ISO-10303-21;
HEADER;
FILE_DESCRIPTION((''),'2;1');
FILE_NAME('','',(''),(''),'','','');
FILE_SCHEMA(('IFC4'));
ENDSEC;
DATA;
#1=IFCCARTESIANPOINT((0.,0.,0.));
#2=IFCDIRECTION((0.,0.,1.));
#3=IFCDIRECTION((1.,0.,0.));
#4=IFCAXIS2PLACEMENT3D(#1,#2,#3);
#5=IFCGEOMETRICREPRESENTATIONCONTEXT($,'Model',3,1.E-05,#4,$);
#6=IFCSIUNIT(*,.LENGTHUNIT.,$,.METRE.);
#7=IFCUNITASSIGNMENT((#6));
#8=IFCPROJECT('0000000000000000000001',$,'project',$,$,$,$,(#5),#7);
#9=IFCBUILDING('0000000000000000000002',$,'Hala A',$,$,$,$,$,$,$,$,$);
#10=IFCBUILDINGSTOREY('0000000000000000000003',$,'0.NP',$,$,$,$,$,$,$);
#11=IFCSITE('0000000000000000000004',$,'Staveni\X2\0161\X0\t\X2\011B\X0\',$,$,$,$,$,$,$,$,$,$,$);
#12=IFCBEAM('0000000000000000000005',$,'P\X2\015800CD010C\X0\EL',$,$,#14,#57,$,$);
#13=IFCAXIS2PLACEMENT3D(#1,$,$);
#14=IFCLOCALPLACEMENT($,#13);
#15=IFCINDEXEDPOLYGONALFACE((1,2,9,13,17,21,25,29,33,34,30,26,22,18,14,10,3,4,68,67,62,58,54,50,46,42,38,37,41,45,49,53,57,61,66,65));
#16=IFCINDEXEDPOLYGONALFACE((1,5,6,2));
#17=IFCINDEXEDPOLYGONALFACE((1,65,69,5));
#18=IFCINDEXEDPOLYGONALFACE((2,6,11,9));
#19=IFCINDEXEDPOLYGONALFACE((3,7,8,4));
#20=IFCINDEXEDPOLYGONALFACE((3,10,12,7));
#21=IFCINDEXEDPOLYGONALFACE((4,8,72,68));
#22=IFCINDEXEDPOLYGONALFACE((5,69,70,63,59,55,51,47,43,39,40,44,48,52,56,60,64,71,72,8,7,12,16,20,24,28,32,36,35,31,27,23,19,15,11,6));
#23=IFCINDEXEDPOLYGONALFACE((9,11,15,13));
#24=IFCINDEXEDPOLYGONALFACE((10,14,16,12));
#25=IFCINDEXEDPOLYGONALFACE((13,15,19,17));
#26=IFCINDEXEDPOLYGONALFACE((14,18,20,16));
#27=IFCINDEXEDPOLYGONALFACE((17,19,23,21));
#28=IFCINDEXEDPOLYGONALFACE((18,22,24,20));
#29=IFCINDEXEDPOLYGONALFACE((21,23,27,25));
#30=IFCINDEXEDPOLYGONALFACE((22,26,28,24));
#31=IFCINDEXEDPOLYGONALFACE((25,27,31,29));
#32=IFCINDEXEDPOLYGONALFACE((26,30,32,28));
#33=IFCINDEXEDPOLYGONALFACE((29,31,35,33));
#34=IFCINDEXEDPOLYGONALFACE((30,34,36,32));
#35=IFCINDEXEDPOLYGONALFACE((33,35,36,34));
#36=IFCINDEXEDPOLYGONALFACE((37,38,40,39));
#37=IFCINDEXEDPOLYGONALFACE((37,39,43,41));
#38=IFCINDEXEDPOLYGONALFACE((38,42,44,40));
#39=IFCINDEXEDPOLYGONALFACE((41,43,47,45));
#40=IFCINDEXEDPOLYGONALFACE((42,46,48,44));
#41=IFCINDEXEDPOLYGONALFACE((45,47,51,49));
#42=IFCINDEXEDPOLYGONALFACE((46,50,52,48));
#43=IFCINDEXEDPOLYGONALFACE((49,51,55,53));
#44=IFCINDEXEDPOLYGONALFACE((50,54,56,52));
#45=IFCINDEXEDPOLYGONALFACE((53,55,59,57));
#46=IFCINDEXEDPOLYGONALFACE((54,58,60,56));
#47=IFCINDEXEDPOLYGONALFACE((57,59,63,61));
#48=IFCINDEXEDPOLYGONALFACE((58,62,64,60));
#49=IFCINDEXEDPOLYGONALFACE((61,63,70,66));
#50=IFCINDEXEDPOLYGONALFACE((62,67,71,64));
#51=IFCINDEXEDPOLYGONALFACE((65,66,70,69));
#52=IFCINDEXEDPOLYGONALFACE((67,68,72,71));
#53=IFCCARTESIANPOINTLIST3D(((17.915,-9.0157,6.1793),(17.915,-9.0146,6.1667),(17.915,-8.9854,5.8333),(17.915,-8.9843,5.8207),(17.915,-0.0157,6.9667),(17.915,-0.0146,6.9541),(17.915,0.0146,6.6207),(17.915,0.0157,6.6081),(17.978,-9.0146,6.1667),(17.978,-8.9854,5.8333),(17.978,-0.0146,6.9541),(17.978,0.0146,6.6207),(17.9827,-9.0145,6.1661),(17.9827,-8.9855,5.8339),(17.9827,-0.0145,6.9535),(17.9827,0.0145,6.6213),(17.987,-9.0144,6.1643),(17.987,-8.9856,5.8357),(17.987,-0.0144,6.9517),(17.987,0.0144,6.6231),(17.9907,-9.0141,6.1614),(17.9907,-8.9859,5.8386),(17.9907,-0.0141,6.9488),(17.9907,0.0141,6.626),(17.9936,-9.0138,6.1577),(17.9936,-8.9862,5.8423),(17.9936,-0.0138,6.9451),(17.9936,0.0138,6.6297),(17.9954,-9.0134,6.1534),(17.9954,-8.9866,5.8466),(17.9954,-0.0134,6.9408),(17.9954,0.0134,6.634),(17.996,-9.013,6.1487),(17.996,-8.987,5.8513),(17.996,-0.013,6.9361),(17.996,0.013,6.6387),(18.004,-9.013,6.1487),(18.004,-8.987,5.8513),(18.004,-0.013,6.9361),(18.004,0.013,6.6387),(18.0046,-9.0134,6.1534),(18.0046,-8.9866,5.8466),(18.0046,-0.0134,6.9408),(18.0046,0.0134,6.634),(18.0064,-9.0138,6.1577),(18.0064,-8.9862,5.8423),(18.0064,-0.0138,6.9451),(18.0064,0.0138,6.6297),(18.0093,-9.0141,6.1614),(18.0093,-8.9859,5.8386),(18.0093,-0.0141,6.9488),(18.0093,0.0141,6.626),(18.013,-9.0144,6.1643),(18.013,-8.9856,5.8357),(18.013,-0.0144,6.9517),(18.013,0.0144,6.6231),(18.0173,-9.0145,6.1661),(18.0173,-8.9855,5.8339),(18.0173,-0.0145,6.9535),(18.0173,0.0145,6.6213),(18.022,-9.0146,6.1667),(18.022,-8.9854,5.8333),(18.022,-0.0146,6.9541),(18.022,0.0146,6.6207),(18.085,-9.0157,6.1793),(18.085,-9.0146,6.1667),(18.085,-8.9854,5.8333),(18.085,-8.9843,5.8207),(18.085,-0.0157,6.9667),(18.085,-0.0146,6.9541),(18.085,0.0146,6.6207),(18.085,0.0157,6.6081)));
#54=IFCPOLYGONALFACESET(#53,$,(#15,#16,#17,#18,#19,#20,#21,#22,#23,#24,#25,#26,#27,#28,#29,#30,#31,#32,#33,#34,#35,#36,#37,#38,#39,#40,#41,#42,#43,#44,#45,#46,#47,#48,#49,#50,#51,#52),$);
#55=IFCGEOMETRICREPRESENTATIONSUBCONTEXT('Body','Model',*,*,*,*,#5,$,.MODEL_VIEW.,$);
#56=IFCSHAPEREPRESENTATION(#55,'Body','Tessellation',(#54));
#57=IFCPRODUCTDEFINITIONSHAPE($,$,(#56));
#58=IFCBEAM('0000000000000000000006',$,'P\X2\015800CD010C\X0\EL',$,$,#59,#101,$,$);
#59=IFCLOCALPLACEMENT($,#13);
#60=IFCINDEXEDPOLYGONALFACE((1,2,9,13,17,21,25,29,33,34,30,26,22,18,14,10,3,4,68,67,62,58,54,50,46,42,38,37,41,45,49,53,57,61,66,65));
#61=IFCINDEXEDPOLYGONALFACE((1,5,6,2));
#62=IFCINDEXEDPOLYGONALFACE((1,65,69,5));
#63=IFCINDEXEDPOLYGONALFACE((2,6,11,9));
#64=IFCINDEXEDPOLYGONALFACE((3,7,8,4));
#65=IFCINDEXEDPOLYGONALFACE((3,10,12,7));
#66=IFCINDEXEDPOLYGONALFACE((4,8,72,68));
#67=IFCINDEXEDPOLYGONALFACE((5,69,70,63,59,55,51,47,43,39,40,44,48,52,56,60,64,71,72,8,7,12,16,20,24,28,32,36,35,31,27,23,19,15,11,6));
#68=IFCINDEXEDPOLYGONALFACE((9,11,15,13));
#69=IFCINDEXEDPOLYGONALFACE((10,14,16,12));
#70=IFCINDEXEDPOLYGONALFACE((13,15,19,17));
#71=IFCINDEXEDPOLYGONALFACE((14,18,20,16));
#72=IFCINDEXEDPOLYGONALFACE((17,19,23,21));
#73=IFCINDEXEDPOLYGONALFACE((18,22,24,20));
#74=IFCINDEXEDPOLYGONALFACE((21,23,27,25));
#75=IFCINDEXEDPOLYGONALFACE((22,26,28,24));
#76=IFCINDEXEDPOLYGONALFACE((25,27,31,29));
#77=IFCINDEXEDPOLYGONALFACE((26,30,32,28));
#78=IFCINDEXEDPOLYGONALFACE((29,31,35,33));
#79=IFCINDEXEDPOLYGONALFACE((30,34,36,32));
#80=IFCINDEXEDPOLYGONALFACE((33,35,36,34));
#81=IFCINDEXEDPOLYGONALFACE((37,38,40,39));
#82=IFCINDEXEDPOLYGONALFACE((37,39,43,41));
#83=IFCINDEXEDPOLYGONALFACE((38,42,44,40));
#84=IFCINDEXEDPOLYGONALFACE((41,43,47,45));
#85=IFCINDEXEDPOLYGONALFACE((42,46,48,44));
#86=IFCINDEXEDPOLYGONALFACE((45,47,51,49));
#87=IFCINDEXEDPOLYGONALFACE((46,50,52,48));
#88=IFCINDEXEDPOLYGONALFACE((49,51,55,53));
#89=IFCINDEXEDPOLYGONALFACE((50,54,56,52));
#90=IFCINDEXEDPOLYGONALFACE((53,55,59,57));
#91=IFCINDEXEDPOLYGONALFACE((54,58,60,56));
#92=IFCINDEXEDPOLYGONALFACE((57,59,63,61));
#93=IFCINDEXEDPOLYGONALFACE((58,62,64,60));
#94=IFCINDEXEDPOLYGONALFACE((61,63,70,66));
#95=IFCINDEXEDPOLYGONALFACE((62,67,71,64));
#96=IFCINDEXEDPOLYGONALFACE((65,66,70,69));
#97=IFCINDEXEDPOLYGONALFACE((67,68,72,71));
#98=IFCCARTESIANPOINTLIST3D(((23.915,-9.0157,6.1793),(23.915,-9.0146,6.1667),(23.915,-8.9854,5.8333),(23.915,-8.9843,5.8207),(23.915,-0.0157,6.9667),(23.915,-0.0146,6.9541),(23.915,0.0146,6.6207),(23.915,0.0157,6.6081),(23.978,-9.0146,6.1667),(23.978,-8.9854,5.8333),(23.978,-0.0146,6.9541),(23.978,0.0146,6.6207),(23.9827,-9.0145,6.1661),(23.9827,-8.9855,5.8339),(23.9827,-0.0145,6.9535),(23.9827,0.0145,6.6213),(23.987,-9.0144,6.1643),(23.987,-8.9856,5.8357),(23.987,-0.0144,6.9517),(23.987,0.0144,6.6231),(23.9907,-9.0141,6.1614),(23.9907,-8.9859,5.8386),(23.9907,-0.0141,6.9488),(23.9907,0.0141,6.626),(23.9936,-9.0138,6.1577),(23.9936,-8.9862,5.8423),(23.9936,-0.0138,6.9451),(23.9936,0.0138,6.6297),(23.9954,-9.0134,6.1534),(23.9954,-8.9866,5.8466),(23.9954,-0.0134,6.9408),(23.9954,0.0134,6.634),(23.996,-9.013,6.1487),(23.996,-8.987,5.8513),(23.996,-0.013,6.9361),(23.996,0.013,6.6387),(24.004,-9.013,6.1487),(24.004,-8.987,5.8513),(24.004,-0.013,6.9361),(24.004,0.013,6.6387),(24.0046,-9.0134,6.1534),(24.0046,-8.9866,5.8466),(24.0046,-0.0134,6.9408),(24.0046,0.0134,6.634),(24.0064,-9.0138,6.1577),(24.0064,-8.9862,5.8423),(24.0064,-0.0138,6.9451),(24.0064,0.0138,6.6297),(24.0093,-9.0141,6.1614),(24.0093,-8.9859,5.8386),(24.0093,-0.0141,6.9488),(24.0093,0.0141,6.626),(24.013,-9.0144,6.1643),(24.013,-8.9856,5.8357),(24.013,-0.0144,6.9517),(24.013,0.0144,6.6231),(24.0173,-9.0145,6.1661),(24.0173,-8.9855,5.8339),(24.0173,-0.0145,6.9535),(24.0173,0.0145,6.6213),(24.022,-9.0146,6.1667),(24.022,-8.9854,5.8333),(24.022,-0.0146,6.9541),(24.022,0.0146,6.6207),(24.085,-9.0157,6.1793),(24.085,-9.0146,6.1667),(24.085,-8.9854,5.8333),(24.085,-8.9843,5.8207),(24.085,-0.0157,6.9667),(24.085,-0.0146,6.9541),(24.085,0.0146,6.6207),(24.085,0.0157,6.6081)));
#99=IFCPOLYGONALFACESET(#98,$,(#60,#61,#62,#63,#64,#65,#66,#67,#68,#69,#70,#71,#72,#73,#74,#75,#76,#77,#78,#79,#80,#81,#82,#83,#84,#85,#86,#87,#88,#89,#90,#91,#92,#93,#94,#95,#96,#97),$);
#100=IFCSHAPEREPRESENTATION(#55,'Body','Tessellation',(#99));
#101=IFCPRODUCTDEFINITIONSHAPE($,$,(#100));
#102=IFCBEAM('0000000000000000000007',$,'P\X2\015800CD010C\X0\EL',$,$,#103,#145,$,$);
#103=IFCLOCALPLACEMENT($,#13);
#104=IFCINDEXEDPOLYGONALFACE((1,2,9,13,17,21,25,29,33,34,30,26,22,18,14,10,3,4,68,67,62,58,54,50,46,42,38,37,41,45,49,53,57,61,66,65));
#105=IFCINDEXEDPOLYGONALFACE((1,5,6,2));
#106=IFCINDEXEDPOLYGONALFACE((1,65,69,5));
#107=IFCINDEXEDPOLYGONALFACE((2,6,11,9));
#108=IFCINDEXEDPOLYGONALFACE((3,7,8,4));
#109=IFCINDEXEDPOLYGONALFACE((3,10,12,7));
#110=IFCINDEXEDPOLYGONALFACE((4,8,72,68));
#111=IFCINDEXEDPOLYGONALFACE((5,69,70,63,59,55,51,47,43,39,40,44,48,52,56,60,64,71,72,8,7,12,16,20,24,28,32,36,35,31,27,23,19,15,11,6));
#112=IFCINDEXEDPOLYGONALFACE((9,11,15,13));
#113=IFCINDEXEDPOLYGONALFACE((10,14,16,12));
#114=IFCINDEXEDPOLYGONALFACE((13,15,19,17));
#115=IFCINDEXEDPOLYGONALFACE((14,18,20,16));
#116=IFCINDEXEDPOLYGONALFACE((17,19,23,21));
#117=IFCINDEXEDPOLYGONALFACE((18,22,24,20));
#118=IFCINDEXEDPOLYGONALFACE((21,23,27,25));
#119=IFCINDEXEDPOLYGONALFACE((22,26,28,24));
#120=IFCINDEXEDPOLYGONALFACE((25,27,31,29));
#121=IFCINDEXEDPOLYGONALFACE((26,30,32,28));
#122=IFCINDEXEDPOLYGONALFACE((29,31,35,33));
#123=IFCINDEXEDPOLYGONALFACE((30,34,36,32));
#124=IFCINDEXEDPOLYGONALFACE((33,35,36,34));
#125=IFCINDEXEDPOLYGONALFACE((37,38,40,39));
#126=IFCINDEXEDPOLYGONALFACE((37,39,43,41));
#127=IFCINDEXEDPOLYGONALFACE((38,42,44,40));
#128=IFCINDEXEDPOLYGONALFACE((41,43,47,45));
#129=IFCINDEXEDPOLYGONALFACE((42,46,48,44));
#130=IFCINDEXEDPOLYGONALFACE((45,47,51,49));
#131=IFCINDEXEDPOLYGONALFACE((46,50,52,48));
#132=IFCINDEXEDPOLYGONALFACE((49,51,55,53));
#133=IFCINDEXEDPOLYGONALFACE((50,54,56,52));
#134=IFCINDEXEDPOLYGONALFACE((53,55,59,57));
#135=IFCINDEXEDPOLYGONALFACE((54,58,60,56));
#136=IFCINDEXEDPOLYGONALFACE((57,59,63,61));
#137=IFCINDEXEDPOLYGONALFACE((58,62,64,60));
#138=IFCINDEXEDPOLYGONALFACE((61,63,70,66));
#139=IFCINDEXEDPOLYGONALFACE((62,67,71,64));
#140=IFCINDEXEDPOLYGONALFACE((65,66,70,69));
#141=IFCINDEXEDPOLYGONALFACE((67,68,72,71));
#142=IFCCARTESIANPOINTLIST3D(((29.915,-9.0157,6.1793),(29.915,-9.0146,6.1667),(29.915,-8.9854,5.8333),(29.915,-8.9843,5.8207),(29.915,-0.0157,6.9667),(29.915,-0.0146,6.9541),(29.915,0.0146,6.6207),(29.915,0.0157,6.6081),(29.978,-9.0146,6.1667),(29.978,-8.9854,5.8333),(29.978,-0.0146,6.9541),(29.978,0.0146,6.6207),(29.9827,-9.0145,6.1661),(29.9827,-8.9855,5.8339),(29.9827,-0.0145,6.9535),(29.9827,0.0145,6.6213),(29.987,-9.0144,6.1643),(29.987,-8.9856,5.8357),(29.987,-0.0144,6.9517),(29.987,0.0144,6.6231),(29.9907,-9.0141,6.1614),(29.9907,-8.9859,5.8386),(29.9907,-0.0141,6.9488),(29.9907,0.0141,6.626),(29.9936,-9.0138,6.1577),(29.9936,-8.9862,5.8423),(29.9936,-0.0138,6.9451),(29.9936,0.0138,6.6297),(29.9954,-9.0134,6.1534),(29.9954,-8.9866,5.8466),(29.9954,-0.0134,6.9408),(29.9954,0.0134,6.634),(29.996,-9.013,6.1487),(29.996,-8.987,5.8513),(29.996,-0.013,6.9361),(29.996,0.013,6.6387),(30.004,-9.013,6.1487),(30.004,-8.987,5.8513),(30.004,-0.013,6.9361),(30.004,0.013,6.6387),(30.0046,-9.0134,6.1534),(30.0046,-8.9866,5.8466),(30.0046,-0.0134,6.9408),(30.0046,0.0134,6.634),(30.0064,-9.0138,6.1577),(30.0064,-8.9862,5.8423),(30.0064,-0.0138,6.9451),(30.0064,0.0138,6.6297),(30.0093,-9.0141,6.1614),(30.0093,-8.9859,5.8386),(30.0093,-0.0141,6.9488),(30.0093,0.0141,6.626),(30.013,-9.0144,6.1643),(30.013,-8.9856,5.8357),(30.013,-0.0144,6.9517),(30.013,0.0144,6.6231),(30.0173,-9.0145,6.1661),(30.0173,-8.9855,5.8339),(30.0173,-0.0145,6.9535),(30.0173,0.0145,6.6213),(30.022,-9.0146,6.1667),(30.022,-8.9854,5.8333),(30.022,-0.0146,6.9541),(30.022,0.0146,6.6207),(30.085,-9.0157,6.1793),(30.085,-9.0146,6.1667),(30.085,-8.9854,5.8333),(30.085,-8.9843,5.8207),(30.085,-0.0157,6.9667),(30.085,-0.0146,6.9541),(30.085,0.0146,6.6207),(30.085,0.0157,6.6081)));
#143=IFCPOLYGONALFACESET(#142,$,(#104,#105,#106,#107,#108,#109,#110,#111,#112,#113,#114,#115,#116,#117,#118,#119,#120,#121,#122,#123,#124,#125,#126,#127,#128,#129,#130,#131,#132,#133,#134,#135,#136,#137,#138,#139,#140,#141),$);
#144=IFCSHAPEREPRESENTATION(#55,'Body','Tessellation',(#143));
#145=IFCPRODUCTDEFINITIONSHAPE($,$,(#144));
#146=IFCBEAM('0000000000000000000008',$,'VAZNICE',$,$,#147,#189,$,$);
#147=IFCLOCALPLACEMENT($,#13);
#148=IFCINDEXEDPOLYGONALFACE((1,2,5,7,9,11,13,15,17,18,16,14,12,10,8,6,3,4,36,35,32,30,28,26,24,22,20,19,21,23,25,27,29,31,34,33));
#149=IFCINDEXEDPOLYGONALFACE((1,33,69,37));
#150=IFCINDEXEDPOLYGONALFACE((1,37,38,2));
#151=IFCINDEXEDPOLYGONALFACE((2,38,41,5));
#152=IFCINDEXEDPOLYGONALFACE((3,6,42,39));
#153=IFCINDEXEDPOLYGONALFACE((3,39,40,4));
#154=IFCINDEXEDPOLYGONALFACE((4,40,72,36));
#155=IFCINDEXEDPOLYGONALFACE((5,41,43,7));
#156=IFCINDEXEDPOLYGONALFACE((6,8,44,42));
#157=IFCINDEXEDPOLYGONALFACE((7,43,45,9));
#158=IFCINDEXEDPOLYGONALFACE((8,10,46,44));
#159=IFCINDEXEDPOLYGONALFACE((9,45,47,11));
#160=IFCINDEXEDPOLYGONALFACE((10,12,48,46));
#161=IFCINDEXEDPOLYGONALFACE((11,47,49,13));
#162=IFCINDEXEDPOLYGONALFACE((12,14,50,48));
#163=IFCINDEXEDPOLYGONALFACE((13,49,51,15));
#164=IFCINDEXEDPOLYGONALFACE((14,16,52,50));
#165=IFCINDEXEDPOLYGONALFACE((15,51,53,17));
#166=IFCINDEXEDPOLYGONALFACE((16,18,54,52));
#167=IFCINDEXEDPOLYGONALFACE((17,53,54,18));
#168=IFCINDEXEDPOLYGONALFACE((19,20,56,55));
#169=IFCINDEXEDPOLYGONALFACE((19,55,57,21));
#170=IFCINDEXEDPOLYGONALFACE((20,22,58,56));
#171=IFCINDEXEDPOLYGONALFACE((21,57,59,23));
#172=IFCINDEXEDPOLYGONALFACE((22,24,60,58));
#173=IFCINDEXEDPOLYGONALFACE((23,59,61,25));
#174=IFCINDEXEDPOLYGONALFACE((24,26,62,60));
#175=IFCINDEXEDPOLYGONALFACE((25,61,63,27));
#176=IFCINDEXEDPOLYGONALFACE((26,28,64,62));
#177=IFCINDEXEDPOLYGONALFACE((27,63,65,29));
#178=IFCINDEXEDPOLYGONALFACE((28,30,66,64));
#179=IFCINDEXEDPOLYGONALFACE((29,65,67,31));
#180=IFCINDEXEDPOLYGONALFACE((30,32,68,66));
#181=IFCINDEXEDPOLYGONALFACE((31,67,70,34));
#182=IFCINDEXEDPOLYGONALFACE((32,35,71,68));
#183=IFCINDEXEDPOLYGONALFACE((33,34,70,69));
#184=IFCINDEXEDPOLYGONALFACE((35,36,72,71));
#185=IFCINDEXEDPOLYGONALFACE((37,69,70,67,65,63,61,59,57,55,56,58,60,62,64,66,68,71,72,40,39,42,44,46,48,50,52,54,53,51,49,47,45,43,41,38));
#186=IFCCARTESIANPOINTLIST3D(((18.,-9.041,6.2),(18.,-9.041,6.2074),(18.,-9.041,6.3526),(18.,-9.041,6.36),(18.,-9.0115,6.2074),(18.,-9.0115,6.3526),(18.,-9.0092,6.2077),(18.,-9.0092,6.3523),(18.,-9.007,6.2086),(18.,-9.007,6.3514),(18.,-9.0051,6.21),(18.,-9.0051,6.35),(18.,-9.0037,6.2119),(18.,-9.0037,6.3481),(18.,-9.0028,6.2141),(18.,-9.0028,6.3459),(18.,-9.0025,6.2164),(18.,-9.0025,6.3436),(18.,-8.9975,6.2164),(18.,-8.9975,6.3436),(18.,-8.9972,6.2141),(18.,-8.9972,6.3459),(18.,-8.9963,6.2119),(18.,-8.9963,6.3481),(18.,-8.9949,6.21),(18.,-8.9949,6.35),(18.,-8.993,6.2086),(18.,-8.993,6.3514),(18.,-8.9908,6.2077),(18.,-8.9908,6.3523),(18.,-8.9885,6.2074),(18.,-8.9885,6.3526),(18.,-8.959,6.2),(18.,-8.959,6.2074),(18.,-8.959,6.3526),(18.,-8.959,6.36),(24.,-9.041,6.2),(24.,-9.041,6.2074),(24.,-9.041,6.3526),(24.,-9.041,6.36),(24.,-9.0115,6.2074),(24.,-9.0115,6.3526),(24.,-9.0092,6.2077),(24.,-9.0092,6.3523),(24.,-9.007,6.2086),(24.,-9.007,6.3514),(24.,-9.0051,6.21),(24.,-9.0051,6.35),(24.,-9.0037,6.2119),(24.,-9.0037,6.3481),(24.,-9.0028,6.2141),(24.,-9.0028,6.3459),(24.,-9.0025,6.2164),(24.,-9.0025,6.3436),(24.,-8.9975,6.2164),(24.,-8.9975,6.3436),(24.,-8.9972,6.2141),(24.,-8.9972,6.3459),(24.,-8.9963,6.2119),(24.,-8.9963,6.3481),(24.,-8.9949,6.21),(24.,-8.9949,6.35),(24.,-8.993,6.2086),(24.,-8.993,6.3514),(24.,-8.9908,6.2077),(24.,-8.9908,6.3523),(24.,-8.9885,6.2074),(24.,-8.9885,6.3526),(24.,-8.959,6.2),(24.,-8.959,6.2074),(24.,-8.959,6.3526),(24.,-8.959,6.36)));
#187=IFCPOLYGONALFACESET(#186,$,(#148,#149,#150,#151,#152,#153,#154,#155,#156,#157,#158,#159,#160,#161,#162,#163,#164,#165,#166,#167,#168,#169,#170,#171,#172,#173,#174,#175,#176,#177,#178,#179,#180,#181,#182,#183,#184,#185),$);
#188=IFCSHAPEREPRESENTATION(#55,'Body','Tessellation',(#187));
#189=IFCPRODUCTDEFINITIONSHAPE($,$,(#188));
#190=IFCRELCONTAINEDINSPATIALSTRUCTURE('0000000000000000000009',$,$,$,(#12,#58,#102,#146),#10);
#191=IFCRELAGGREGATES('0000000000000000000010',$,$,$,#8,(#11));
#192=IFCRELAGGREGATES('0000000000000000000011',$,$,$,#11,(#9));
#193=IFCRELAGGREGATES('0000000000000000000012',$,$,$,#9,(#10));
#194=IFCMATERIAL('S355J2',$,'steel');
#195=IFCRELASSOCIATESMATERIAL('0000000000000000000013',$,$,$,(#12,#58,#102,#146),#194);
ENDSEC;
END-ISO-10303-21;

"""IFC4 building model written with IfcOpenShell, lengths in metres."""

from ifc_helpers import new_model, si_unit, frame, origin_with_axes, place, context, subcontext, project, spatial, i_section, extrude, material, element, save


model = new_model("IFC4")

# Units and contexts
model_context = context("Model", 3, precision=1e-05, world=origin_with_axes())
body_context = subcontext(model_context, "Body", "Model", "MODEL_VIEW")
ifc_project = project(units=[si_unit("LENGTHUNIT", "METRE")], contexts=[model_context])

# Site, building, storey
site = spatial("IfcSite", under=ifc_project, Name="Staveniště")
building = spatial("IfcBuilding", under=site, Name="Hala A")
storey = spatial("IfcBuildingStorey", under=building, Name="0.NP")

# Shared definitions
ifc_material = material(Name="S355J2", Category="steel")

# Beams
for number, where, z_axis, x_axis, name in (
    (1, (18.0, -9.0, 6.0), (0.0, 0.996195, 0.087156), (-1.0, 0.0, 0.0), "PŘÍČEL"),
    (2, (24.0, -9.0, 6.0), (0.0, 0.996195, 0.087156), (-1.0, 0.0, 0.0), "PŘÍČEL"),
    (3, (30.0, -9.0, 6.0), (0.0, 0.996195, 0.087156), (-1.0, 0.0, 0.0), "PŘÍČEL"),
):
    element("IfcBeam", number, at=place(None, frame(where, z_axis=z_axis, x_axis=x_axis)), inside=storey, material=ifc_material, Name=name, context=body_context, shape_type="SweptSolid", body=[
        extrude(i_section(OverallWidth=0.17, OverallDepth=0.36, WebThickness=0.008, FlangeThickness=0.0127, FilletRadius=0.018), origin_with_axes(), (0.0, 0.0, 1.0), 9.0344),
    ])
for number, where, z_axis, x_axis, name in (
    (4, (18.0, -9.0, 6.28), (1.0, 0.0, 0.0), (0.0, 1.0, 0.0), "VAZNICE"),
):
    element("IfcBeam", number, at=place(None, frame(where, z_axis=z_axis, x_axis=x_axis)), inside=storey, material=ifc_material, Name=name, context=body_context, shape_type="SweptSolid", body=[
        extrude(i_section(OverallWidth=0.082, OverallDepth=0.16, WebThickness=0.005, FlangeThickness=0.0074, FilletRadius=0.009), origin_with_axes(), (0.0, 0.0, 1.0), 6.0),
    ])

save(model, "model.ifc")
